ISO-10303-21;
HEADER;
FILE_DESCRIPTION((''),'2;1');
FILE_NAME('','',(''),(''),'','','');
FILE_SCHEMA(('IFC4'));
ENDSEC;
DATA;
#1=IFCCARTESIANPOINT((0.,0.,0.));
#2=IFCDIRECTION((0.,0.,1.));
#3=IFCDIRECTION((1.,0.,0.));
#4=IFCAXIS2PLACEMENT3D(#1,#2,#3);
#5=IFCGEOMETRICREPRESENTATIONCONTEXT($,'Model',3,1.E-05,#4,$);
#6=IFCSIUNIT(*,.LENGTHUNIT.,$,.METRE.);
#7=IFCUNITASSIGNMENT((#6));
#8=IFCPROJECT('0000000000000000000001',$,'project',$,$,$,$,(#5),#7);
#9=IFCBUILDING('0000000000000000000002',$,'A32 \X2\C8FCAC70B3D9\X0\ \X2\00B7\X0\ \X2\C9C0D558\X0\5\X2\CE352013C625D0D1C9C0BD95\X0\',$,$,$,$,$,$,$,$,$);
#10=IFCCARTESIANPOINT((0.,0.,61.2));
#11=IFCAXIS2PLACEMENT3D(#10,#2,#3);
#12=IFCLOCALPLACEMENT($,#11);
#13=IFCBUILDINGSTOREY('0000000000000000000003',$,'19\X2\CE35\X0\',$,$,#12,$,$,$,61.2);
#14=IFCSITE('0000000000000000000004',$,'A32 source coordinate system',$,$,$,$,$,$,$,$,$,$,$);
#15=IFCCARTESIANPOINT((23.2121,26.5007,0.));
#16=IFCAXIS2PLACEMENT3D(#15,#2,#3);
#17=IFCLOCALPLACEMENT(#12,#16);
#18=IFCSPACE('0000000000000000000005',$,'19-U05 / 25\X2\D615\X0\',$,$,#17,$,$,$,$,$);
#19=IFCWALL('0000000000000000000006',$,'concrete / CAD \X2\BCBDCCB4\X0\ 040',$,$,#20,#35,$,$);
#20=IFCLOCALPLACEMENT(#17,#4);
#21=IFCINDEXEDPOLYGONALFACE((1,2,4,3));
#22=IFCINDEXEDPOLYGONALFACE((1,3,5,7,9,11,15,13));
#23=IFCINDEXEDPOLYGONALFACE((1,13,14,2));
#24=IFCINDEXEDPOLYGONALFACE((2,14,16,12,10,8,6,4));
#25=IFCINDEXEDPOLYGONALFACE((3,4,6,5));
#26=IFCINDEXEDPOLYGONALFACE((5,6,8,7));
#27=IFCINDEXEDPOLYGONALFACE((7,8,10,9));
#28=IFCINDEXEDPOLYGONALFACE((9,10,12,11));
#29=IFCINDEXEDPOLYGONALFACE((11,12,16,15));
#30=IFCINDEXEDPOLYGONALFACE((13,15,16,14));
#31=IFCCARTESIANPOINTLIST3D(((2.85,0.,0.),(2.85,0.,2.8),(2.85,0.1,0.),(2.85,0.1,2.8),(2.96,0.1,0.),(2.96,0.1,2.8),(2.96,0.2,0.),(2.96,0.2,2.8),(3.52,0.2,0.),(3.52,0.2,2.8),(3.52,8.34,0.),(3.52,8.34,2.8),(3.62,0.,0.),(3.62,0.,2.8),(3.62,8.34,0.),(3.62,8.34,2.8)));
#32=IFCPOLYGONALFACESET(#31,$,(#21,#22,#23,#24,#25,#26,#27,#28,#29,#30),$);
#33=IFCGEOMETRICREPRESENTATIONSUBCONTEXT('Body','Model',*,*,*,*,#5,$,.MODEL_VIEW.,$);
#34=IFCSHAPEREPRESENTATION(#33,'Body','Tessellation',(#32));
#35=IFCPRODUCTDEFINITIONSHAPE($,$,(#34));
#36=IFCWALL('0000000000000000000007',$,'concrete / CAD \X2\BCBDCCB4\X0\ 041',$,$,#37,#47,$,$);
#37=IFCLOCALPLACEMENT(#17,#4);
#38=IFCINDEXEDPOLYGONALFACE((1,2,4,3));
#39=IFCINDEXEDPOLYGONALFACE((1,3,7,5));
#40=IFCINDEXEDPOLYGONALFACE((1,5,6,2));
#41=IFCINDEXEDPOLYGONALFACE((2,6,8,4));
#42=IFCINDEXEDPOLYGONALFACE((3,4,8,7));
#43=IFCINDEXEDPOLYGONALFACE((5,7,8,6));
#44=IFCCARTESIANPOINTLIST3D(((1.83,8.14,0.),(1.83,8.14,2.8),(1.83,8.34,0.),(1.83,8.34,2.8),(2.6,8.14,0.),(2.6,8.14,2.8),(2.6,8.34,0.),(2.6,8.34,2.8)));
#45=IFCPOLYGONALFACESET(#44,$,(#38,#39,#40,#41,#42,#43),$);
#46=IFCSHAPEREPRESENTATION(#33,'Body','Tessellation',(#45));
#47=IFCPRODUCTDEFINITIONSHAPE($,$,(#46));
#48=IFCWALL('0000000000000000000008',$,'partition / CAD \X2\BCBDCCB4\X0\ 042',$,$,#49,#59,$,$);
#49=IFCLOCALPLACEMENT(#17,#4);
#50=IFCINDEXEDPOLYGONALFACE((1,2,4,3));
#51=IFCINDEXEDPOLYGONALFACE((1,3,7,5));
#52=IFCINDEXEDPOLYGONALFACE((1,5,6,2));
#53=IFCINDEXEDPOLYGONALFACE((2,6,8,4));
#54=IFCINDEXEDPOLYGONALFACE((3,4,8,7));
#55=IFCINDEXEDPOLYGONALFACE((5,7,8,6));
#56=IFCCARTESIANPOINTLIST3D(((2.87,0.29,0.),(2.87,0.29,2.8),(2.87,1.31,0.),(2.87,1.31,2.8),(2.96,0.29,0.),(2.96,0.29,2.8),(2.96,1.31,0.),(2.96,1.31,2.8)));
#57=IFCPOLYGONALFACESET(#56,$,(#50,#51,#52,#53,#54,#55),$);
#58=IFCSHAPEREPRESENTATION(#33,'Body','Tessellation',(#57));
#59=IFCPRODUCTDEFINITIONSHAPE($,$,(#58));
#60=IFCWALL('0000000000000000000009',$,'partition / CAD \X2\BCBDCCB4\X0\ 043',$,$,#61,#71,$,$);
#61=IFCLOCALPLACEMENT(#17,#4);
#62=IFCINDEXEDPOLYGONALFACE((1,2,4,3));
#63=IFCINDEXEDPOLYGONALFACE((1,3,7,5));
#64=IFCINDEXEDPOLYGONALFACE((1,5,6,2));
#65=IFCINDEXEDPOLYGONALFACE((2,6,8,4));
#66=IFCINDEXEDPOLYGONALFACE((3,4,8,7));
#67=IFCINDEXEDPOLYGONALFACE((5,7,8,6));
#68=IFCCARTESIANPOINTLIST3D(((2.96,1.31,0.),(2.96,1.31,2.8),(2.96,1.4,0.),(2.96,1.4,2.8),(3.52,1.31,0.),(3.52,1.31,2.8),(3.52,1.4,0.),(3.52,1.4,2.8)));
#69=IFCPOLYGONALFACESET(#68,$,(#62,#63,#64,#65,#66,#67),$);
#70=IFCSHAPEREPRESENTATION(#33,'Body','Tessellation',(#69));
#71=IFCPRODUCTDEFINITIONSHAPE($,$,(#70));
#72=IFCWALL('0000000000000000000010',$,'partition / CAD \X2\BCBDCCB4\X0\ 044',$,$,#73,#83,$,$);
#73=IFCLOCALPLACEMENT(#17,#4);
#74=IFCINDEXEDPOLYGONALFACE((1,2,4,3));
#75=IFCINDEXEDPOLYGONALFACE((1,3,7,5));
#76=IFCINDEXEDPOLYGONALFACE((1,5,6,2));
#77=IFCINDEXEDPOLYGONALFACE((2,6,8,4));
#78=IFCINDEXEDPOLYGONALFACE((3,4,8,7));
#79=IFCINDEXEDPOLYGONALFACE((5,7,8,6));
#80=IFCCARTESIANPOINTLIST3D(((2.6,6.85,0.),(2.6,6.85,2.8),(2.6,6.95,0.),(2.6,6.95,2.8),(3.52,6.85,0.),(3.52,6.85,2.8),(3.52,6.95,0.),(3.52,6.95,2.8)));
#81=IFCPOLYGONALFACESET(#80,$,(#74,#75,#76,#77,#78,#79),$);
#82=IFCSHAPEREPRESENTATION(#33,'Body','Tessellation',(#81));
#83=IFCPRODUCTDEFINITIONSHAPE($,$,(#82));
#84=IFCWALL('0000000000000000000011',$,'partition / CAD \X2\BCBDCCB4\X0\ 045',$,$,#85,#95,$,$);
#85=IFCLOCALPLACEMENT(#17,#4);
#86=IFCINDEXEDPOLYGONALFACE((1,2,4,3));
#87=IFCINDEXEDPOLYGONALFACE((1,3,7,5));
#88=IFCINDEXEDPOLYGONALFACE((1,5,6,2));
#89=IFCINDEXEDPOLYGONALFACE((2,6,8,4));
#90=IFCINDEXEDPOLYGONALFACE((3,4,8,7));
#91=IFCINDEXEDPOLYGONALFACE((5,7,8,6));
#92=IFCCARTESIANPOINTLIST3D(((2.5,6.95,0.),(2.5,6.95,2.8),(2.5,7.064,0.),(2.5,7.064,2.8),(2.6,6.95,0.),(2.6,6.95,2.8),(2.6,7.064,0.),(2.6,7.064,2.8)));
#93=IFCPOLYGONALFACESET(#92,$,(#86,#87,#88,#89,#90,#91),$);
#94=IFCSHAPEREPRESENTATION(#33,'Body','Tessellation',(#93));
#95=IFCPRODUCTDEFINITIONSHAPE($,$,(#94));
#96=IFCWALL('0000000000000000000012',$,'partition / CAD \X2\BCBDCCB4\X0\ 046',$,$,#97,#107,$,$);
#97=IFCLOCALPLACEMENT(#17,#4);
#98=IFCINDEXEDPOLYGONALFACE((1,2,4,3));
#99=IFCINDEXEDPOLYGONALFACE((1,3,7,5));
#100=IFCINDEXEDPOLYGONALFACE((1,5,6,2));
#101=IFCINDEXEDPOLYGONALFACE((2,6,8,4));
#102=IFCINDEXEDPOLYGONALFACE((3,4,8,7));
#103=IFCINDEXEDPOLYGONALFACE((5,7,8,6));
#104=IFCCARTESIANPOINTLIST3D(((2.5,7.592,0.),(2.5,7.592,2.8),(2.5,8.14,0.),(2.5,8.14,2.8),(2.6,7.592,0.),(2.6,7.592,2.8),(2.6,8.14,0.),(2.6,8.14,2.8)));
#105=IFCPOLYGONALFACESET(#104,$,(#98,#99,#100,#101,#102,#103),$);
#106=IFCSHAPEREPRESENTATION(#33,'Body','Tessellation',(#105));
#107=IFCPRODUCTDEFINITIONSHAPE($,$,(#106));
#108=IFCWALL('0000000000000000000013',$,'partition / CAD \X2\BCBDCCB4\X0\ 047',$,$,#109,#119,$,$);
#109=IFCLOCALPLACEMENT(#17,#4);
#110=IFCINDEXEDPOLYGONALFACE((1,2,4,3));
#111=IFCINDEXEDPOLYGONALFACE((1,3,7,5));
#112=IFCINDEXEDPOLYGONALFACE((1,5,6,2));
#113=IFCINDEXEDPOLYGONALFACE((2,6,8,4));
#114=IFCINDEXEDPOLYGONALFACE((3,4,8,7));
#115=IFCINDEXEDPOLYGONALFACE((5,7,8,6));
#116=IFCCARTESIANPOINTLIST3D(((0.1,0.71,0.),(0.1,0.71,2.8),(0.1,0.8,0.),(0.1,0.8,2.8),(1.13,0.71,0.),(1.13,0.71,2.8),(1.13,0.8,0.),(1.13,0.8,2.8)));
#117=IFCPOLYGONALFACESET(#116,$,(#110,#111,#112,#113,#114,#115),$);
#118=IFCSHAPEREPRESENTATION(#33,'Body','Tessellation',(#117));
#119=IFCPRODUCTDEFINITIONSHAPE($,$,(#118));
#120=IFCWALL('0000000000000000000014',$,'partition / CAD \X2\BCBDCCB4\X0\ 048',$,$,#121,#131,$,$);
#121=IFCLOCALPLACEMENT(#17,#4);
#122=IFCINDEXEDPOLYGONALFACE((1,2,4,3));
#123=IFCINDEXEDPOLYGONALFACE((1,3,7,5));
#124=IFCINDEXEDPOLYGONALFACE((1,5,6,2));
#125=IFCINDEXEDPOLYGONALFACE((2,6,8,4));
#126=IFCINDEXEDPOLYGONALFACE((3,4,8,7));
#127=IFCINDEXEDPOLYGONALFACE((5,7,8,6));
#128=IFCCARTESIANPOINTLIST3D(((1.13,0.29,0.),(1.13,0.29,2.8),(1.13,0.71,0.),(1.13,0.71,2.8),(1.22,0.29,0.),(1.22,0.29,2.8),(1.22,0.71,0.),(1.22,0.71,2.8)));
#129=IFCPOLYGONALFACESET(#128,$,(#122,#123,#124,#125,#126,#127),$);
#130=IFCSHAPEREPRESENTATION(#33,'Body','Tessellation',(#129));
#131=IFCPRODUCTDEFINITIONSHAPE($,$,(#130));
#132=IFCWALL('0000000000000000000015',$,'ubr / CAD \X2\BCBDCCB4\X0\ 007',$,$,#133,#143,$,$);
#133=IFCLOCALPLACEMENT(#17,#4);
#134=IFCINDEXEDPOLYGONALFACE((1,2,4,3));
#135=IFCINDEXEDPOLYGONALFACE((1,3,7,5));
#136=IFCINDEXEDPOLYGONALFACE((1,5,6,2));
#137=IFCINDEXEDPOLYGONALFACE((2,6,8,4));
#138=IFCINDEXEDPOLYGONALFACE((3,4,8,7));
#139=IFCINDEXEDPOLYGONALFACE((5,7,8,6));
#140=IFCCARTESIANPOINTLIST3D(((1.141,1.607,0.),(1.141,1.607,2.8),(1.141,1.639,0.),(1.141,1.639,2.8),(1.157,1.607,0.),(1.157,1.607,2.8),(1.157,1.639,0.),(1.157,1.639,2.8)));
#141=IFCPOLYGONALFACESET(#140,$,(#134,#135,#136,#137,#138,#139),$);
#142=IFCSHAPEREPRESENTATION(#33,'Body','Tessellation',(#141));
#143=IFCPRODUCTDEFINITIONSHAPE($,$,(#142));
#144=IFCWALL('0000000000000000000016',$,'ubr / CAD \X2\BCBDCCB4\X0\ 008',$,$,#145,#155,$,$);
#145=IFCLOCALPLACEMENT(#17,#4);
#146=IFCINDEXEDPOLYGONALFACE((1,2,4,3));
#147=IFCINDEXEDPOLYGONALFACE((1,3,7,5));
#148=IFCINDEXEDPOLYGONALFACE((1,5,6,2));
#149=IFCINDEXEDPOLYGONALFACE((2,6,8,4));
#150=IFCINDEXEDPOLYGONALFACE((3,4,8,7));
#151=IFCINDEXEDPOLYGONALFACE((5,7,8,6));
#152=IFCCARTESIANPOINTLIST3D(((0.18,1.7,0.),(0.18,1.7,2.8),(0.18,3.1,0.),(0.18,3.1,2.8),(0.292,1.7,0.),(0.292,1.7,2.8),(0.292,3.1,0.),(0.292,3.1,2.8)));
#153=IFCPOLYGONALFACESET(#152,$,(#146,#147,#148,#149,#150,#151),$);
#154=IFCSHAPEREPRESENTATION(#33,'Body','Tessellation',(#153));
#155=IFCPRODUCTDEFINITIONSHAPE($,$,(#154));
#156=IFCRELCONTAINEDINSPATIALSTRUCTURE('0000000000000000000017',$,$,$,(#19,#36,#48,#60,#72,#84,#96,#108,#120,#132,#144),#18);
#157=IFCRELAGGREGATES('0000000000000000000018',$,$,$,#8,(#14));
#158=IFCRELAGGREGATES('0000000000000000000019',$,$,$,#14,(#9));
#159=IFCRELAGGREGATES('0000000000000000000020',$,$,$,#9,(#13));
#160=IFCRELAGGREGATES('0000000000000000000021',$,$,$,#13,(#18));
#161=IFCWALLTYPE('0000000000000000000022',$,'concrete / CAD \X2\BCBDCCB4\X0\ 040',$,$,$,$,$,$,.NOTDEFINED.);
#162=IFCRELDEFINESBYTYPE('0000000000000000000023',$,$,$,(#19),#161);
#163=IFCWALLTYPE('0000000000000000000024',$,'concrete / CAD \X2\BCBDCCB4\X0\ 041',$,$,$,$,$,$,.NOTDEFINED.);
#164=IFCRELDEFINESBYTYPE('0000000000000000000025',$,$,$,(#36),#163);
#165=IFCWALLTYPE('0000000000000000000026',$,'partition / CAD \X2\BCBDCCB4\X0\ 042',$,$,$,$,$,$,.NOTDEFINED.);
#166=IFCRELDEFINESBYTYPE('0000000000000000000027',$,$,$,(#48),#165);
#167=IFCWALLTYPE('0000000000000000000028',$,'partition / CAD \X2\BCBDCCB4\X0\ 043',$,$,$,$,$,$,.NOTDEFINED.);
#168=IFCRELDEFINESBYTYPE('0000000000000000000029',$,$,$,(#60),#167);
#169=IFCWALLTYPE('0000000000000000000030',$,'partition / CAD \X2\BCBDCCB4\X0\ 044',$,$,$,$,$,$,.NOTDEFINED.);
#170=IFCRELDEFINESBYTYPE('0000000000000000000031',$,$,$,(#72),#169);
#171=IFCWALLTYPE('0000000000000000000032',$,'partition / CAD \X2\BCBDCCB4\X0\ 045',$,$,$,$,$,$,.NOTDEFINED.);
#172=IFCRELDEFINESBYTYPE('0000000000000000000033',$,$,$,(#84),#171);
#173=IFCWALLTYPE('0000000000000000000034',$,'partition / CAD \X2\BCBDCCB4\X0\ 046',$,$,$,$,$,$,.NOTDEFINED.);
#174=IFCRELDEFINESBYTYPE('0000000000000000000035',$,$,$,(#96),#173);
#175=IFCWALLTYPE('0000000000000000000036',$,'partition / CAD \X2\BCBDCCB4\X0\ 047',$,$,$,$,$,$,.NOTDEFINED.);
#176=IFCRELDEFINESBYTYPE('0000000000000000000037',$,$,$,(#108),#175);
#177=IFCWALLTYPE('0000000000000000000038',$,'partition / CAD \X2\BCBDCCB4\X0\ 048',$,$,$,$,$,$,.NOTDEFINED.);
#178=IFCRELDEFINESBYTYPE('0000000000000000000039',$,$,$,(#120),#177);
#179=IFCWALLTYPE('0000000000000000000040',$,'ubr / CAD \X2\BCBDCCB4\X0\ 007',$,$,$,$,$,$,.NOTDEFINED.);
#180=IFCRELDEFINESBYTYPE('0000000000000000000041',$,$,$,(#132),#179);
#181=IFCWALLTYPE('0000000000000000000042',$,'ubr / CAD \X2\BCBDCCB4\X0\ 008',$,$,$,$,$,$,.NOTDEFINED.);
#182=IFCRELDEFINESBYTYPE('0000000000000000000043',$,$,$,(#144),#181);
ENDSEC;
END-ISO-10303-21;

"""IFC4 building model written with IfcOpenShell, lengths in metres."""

from ifc_helpers import new_model, si_unit, frame, origin, origin_with_axes, place, context, subcontext, project, spatial, polyline, outline, extrude, source, transform, mapped, type_object, type_shapes, element, save


model = new_model("IFC4")

# Units and contexts
model_context = context("Model", 3, precision=1e-05, world=origin_with_axes())
body_context = subcontext(model_context, "Body", "Model", "MODEL_VIEW")
ifc_project = project(units=[si_unit("LENGTHUNIT", "METRE")], contexts=[model_context])

# Site, building, storey, space
site = spatial("IfcSite", under=ifc_project, Name="A32 source coordinate system")
building = spatial("IfcBuilding", under=site, Name="A32 주거동 · 지하5층–옥탑지붕")
storey_placement = place(None, frame((0.0, 0.0, 61.2), z_axis=(0.0, 0.0, 1.0), x_axis=(1.0, 0.0, 0.0)))
storey = spatial("IfcBuildingStorey", under=building, at=storey_placement, Name="19층", Elevation=61.2)
space_1_placement = place(storey_placement, frame((23.2121, 26.5007, 0.0), z_axis=(0.0, 0.0, 1.0), x_axis=(1.0, 0.0, 0.0)))
space_1 = spatial("IfcSpace", under=storey, at=space_1_placement, Name="19-U05 / 25형")

# Walls
wall_type_1 = type_object("IfcWallType", Name="concrete / CAD 벽체 040", PredefinedType="NOTDEFINED")
shared_shape_1 = source(origin(), body_context, "Body", "SweptSolid", [
    extrude(outline(polyline([(3.62, 8.34), (3.62, 0.0), (2.85, 0.0), (2.85, 0.1), (2.96, 0.1), (2.96, 0.2), (3.52, 0.2), (3.52, 8.34), (3.62, 8.34)])), origin(), (0.0, 0.0, 1.0), 2.8),
])
type_shapes(wall_type_1, [shared_shape_1])
wall_1_placement = place(space_1_placement, origin_with_axes())
element("IfcWall", 1, at=wall_1_placement, inside=space_1, type_object=wall_type_1, Name="concrete / CAD 벽체 040", context=body_context, shape_type="MappedRepresentation", body=[
    mapped(shared_shape_1, transform((0.0, 0.0, 0.0), scale=1.0)),
])
wall_type_2 = type_object("IfcWallType", Name="concrete / CAD 벽체 041", PredefinedType="NOTDEFINED")
shared_shape_2 = source(origin(), body_context, "Body", "SweptSolid", [
    extrude(outline(polyline([(2.6, 8.14), (1.83, 8.14), (1.83, 8.34), (2.6, 8.34), (2.6, 8.14)])), origin(), (0.0, 0.0, 1.0), 2.8),
])
type_shapes(wall_type_2, [shared_shape_2])
wall_2_placement = place(space_1_placement, origin_with_axes())
element("IfcWall", 2, at=wall_2_placement, inside=space_1, type_object=wall_type_2, Name="concrete / CAD 벽체 041", context=body_context, shape_type="MappedRepresentation", body=[
    mapped(shared_shape_2, transform((0.0, 0.0, 0.0), scale=1.0)),
])
wall_type_3 = type_object("IfcWallType", Name="partition / CAD 벽체 042", PredefinedType="NOTDEFINED")
shared_shape_3 = source(origin(), body_context, "Body", "SweptSolid", [
    extrude(outline(polyline([(2.87, 1.31), (2.96, 1.31), (2.96, 0.29), (2.87, 0.29), (2.87, 1.31)])), origin(), (0.0, 0.0, 1.0), 2.8),
])
type_shapes(wall_type_3, [shared_shape_3])
wall_3_placement = place(space_1_placement, origin_with_axes())
element("IfcWall", 3, at=wall_3_placement, inside=space_1, type_object=wall_type_3, Name="partition / CAD 벽체 042", context=body_context, shape_type="MappedRepresentation", body=[
    mapped(shared_shape_3, transform((0.0, 0.0, 0.0), scale=1.0)),
])
wall_type_4 = type_object("IfcWallType", Name="partition / CAD 벽체 043", PredefinedType="NOTDEFINED")
shared_shape_4 = source(origin(), body_context, "Body", "SweptSolid", [
    extrude(outline(polyline([(3.52, 1.4), (3.52, 1.31), (2.96, 1.31), (2.96, 1.4), (3.52, 1.4)])), origin(), (0.0, 0.0, 1.0), 2.8),
])
type_shapes(wall_type_4, [shared_shape_4])
wall_4_placement = place(space_1_placement, origin_with_axes())
element("IfcWall", 4, at=wall_4_placement, inside=space_1, type_object=wall_type_4, Name="partition / CAD 벽체 043", context=body_context, shape_type="MappedRepresentation", body=[
    mapped(shared_shape_4, transform((0.0, 0.0, 0.0), scale=1.0)),
])
wall_type_5 = type_object("IfcWallType", Name="partition / CAD 벽체 044", PredefinedType="NOTDEFINED")
shared_shape_5 = source(origin(), body_context, "Body", "SweptSolid", [
    extrude(outline(polyline([(3.52, 6.95), (3.52, 6.85), (2.6, 6.85), (2.6, 6.95), (3.52, 6.95)])), origin(), (0.0, 0.0, 1.0), 2.8),
])
type_shapes(wall_type_5, [shared_shape_5])
wall_5_placement = place(space_1_placement, origin_with_axes())
element("IfcWall", 5, at=wall_5_placement, inside=space_1, type_object=wall_type_5, Name="partition / CAD 벽체 044", context=body_context, shape_type="MappedRepresentation", body=[
    mapped(shared_shape_5, transform((0.0, 0.0, 0.0), scale=1.0)),
])
wall_type_6 = type_object("IfcWallType", Name="partition / CAD 벽체 045", PredefinedType="NOTDEFINED")
shared_shape_6 = source(origin(), body_context, "Body", "SweptSolid", [
    extrude(outline(polyline([(2.5, 7.064), (2.6, 7.064), (2.6, 6.95), (2.5, 6.95), (2.5, 7.064)])), origin(), (0.0, 0.0, 1.0), 2.8),
])
type_shapes(wall_type_6, [shared_shape_6])
wall_6_placement = place(space_1_placement, origin_with_axes())
element("IfcWall", 6, at=wall_6_placement, inside=space_1, type_object=wall_type_6, Name="partition / CAD 벽체 045", context=body_context, shape_type="MappedRepresentation", body=[
    mapped(shared_shape_6, transform((0.0, 0.0, 0.0), scale=1.0)),
])
wall_type_7 = type_object("IfcWallType", Name="partition / CAD 벽체 046", PredefinedType="NOTDEFINED")
shared_shape_7 = source(origin(), body_context, "Body", "SweptSolid", [
    extrude(outline(polyline([(2.6, 7.592), (2.5, 7.592), (2.5, 8.14), (2.6, 8.14), (2.6, 7.592)])), origin(), (0.0, 0.0, 1.0), 2.8),
])
type_shapes(wall_type_7, [shared_shape_7])
wall_7_placement = place(space_1_placement, origin_with_axes())
element("IfcWall", 7, at=wall_7_placement, inside=space_1, type_object=wall_type_7, Name="partition / CAD 벽체 046", context=body_context, shape_type="MappedRepresentation", body=[
    mapped(shared_shape_7, transform((0.0, 0.0, 0.0), scale=1.0)),
])
wall_type_8 = type_object("IfcWallType", Name="partition / CAD 벽체 047", PredefinedType="NOTDEFINED")
shared_shape_8 = source(origin(), body_context, "Body", "SweptSolid", [
    extrude(outline(polyline([(1.13, 0.71), (0.1, 0.71), (0.1, 0.8), (1.13, 0.8), (1.13, 0.71)])), origin(), (0.0, 0.0, 1.0), 2.8),
])
type_shapes(wall_type_8, [shared_shape_8])
wall_8_placement = place(space_1_placement, origin_with_axes())
element("IfcWall", 8, at=wall_8_placement, inside=space_1, type_object=wall_type_8, Name="partition / CAD 벽체 047", context=body_context, shape_type="MappedRepresentation", body=[
    mapped(shared_shape_8, transform((0.0, 0.0, 0.0), scale=1.0)),
])
wall_type_9 = type_object("IfcWallType", Name="partition / CAD 벽체 048", PredefinedType="NOTDEFINED")
shared_shape_9 = source(origin(), body_context, "Body", "SweptSolid", [
    extrude(outline(polyline([(1.22, 0.29), (1.13, 0.29), (1.13, 0.71), (1.22, 0.71), (1.22, 0.29)])), origin(), (0.0, 0.0, 1.0), 2.8),
])
type_shapes(wall_type_9, [shared_shape_9])
wall_9_placement = place(space_1_placement, origin_with_axes())
element("IfcWall", 9, at=wall_9_placement, inside=space_1, type_object=wall_type_9, Name="partition / CAD 벽체 048", context=body_context, shape_type="MappedRepresentation", body=[
    mapped(shared_shape_9, transform((0.0, 0.0, 0.0), scale=1.0)),
])
wall_type_10 = type_object("IfcWallType", Name="ubr / CAD 벽체 007", PredefinedType="NOTDEFINED")
shared_shape_10 = source(origin(), body_context, "Body", "SweptSolid", [
    extrude(outline(polyline([(1.157, 1.607), (1.141, 1.607), (1.141, 1.639), (1.157, 1.639), (1.157, 1.607)])), origin(), (0.0, 0.0, 1.0), 2.8),
])
type_shapes(wall_type_10, [shared_shape_10])
wall_10_placement = place(space_1_placement, origin_with_axes())
element("IfcWall", 10, at=wall_10_placement, inside=space_1, type_object=wall_type_10, Name="ubr / CAD 벽체 007", context=body_context, shape_type="MappedRepresentation", body=[
    mapped(shared_shape_10, transform((0.0, 0.0, 0.0), scale=1.0)),
])
wall_type_11 = type_object("IfcWallType", Name="ubr / CAD 벽체 008", PredefinedType="NOTDEFINED")
shared_shape_11 = source(origin(), body_context, "Body", "SweptSolid", [
    extrude(outline(polyline([(0.292, 1.7), (0.18, 1.7), (0.18, 3.1), (0.292, 3.1), (0.292, 1.7)])), origin(), (0.0, 0.0, 1.0), 2.8),
])
type_shapes(wall_type_11, [shared_shape_11])
wall_11_placement = place(space_1_placement, origin_with_axes())
element("IfcWall", 11, at=wall_11_placement, inside=space_1, type_object=wall_type_11, Name="ubr / CAD 벽체 008", context=body_context, shape_type="MappedRepresentation", body=[
    mapped(shared_shape_11, transform((0.0, 0.0, 0.0), scale=1.0)),
])

save(model, "model.ifc")
